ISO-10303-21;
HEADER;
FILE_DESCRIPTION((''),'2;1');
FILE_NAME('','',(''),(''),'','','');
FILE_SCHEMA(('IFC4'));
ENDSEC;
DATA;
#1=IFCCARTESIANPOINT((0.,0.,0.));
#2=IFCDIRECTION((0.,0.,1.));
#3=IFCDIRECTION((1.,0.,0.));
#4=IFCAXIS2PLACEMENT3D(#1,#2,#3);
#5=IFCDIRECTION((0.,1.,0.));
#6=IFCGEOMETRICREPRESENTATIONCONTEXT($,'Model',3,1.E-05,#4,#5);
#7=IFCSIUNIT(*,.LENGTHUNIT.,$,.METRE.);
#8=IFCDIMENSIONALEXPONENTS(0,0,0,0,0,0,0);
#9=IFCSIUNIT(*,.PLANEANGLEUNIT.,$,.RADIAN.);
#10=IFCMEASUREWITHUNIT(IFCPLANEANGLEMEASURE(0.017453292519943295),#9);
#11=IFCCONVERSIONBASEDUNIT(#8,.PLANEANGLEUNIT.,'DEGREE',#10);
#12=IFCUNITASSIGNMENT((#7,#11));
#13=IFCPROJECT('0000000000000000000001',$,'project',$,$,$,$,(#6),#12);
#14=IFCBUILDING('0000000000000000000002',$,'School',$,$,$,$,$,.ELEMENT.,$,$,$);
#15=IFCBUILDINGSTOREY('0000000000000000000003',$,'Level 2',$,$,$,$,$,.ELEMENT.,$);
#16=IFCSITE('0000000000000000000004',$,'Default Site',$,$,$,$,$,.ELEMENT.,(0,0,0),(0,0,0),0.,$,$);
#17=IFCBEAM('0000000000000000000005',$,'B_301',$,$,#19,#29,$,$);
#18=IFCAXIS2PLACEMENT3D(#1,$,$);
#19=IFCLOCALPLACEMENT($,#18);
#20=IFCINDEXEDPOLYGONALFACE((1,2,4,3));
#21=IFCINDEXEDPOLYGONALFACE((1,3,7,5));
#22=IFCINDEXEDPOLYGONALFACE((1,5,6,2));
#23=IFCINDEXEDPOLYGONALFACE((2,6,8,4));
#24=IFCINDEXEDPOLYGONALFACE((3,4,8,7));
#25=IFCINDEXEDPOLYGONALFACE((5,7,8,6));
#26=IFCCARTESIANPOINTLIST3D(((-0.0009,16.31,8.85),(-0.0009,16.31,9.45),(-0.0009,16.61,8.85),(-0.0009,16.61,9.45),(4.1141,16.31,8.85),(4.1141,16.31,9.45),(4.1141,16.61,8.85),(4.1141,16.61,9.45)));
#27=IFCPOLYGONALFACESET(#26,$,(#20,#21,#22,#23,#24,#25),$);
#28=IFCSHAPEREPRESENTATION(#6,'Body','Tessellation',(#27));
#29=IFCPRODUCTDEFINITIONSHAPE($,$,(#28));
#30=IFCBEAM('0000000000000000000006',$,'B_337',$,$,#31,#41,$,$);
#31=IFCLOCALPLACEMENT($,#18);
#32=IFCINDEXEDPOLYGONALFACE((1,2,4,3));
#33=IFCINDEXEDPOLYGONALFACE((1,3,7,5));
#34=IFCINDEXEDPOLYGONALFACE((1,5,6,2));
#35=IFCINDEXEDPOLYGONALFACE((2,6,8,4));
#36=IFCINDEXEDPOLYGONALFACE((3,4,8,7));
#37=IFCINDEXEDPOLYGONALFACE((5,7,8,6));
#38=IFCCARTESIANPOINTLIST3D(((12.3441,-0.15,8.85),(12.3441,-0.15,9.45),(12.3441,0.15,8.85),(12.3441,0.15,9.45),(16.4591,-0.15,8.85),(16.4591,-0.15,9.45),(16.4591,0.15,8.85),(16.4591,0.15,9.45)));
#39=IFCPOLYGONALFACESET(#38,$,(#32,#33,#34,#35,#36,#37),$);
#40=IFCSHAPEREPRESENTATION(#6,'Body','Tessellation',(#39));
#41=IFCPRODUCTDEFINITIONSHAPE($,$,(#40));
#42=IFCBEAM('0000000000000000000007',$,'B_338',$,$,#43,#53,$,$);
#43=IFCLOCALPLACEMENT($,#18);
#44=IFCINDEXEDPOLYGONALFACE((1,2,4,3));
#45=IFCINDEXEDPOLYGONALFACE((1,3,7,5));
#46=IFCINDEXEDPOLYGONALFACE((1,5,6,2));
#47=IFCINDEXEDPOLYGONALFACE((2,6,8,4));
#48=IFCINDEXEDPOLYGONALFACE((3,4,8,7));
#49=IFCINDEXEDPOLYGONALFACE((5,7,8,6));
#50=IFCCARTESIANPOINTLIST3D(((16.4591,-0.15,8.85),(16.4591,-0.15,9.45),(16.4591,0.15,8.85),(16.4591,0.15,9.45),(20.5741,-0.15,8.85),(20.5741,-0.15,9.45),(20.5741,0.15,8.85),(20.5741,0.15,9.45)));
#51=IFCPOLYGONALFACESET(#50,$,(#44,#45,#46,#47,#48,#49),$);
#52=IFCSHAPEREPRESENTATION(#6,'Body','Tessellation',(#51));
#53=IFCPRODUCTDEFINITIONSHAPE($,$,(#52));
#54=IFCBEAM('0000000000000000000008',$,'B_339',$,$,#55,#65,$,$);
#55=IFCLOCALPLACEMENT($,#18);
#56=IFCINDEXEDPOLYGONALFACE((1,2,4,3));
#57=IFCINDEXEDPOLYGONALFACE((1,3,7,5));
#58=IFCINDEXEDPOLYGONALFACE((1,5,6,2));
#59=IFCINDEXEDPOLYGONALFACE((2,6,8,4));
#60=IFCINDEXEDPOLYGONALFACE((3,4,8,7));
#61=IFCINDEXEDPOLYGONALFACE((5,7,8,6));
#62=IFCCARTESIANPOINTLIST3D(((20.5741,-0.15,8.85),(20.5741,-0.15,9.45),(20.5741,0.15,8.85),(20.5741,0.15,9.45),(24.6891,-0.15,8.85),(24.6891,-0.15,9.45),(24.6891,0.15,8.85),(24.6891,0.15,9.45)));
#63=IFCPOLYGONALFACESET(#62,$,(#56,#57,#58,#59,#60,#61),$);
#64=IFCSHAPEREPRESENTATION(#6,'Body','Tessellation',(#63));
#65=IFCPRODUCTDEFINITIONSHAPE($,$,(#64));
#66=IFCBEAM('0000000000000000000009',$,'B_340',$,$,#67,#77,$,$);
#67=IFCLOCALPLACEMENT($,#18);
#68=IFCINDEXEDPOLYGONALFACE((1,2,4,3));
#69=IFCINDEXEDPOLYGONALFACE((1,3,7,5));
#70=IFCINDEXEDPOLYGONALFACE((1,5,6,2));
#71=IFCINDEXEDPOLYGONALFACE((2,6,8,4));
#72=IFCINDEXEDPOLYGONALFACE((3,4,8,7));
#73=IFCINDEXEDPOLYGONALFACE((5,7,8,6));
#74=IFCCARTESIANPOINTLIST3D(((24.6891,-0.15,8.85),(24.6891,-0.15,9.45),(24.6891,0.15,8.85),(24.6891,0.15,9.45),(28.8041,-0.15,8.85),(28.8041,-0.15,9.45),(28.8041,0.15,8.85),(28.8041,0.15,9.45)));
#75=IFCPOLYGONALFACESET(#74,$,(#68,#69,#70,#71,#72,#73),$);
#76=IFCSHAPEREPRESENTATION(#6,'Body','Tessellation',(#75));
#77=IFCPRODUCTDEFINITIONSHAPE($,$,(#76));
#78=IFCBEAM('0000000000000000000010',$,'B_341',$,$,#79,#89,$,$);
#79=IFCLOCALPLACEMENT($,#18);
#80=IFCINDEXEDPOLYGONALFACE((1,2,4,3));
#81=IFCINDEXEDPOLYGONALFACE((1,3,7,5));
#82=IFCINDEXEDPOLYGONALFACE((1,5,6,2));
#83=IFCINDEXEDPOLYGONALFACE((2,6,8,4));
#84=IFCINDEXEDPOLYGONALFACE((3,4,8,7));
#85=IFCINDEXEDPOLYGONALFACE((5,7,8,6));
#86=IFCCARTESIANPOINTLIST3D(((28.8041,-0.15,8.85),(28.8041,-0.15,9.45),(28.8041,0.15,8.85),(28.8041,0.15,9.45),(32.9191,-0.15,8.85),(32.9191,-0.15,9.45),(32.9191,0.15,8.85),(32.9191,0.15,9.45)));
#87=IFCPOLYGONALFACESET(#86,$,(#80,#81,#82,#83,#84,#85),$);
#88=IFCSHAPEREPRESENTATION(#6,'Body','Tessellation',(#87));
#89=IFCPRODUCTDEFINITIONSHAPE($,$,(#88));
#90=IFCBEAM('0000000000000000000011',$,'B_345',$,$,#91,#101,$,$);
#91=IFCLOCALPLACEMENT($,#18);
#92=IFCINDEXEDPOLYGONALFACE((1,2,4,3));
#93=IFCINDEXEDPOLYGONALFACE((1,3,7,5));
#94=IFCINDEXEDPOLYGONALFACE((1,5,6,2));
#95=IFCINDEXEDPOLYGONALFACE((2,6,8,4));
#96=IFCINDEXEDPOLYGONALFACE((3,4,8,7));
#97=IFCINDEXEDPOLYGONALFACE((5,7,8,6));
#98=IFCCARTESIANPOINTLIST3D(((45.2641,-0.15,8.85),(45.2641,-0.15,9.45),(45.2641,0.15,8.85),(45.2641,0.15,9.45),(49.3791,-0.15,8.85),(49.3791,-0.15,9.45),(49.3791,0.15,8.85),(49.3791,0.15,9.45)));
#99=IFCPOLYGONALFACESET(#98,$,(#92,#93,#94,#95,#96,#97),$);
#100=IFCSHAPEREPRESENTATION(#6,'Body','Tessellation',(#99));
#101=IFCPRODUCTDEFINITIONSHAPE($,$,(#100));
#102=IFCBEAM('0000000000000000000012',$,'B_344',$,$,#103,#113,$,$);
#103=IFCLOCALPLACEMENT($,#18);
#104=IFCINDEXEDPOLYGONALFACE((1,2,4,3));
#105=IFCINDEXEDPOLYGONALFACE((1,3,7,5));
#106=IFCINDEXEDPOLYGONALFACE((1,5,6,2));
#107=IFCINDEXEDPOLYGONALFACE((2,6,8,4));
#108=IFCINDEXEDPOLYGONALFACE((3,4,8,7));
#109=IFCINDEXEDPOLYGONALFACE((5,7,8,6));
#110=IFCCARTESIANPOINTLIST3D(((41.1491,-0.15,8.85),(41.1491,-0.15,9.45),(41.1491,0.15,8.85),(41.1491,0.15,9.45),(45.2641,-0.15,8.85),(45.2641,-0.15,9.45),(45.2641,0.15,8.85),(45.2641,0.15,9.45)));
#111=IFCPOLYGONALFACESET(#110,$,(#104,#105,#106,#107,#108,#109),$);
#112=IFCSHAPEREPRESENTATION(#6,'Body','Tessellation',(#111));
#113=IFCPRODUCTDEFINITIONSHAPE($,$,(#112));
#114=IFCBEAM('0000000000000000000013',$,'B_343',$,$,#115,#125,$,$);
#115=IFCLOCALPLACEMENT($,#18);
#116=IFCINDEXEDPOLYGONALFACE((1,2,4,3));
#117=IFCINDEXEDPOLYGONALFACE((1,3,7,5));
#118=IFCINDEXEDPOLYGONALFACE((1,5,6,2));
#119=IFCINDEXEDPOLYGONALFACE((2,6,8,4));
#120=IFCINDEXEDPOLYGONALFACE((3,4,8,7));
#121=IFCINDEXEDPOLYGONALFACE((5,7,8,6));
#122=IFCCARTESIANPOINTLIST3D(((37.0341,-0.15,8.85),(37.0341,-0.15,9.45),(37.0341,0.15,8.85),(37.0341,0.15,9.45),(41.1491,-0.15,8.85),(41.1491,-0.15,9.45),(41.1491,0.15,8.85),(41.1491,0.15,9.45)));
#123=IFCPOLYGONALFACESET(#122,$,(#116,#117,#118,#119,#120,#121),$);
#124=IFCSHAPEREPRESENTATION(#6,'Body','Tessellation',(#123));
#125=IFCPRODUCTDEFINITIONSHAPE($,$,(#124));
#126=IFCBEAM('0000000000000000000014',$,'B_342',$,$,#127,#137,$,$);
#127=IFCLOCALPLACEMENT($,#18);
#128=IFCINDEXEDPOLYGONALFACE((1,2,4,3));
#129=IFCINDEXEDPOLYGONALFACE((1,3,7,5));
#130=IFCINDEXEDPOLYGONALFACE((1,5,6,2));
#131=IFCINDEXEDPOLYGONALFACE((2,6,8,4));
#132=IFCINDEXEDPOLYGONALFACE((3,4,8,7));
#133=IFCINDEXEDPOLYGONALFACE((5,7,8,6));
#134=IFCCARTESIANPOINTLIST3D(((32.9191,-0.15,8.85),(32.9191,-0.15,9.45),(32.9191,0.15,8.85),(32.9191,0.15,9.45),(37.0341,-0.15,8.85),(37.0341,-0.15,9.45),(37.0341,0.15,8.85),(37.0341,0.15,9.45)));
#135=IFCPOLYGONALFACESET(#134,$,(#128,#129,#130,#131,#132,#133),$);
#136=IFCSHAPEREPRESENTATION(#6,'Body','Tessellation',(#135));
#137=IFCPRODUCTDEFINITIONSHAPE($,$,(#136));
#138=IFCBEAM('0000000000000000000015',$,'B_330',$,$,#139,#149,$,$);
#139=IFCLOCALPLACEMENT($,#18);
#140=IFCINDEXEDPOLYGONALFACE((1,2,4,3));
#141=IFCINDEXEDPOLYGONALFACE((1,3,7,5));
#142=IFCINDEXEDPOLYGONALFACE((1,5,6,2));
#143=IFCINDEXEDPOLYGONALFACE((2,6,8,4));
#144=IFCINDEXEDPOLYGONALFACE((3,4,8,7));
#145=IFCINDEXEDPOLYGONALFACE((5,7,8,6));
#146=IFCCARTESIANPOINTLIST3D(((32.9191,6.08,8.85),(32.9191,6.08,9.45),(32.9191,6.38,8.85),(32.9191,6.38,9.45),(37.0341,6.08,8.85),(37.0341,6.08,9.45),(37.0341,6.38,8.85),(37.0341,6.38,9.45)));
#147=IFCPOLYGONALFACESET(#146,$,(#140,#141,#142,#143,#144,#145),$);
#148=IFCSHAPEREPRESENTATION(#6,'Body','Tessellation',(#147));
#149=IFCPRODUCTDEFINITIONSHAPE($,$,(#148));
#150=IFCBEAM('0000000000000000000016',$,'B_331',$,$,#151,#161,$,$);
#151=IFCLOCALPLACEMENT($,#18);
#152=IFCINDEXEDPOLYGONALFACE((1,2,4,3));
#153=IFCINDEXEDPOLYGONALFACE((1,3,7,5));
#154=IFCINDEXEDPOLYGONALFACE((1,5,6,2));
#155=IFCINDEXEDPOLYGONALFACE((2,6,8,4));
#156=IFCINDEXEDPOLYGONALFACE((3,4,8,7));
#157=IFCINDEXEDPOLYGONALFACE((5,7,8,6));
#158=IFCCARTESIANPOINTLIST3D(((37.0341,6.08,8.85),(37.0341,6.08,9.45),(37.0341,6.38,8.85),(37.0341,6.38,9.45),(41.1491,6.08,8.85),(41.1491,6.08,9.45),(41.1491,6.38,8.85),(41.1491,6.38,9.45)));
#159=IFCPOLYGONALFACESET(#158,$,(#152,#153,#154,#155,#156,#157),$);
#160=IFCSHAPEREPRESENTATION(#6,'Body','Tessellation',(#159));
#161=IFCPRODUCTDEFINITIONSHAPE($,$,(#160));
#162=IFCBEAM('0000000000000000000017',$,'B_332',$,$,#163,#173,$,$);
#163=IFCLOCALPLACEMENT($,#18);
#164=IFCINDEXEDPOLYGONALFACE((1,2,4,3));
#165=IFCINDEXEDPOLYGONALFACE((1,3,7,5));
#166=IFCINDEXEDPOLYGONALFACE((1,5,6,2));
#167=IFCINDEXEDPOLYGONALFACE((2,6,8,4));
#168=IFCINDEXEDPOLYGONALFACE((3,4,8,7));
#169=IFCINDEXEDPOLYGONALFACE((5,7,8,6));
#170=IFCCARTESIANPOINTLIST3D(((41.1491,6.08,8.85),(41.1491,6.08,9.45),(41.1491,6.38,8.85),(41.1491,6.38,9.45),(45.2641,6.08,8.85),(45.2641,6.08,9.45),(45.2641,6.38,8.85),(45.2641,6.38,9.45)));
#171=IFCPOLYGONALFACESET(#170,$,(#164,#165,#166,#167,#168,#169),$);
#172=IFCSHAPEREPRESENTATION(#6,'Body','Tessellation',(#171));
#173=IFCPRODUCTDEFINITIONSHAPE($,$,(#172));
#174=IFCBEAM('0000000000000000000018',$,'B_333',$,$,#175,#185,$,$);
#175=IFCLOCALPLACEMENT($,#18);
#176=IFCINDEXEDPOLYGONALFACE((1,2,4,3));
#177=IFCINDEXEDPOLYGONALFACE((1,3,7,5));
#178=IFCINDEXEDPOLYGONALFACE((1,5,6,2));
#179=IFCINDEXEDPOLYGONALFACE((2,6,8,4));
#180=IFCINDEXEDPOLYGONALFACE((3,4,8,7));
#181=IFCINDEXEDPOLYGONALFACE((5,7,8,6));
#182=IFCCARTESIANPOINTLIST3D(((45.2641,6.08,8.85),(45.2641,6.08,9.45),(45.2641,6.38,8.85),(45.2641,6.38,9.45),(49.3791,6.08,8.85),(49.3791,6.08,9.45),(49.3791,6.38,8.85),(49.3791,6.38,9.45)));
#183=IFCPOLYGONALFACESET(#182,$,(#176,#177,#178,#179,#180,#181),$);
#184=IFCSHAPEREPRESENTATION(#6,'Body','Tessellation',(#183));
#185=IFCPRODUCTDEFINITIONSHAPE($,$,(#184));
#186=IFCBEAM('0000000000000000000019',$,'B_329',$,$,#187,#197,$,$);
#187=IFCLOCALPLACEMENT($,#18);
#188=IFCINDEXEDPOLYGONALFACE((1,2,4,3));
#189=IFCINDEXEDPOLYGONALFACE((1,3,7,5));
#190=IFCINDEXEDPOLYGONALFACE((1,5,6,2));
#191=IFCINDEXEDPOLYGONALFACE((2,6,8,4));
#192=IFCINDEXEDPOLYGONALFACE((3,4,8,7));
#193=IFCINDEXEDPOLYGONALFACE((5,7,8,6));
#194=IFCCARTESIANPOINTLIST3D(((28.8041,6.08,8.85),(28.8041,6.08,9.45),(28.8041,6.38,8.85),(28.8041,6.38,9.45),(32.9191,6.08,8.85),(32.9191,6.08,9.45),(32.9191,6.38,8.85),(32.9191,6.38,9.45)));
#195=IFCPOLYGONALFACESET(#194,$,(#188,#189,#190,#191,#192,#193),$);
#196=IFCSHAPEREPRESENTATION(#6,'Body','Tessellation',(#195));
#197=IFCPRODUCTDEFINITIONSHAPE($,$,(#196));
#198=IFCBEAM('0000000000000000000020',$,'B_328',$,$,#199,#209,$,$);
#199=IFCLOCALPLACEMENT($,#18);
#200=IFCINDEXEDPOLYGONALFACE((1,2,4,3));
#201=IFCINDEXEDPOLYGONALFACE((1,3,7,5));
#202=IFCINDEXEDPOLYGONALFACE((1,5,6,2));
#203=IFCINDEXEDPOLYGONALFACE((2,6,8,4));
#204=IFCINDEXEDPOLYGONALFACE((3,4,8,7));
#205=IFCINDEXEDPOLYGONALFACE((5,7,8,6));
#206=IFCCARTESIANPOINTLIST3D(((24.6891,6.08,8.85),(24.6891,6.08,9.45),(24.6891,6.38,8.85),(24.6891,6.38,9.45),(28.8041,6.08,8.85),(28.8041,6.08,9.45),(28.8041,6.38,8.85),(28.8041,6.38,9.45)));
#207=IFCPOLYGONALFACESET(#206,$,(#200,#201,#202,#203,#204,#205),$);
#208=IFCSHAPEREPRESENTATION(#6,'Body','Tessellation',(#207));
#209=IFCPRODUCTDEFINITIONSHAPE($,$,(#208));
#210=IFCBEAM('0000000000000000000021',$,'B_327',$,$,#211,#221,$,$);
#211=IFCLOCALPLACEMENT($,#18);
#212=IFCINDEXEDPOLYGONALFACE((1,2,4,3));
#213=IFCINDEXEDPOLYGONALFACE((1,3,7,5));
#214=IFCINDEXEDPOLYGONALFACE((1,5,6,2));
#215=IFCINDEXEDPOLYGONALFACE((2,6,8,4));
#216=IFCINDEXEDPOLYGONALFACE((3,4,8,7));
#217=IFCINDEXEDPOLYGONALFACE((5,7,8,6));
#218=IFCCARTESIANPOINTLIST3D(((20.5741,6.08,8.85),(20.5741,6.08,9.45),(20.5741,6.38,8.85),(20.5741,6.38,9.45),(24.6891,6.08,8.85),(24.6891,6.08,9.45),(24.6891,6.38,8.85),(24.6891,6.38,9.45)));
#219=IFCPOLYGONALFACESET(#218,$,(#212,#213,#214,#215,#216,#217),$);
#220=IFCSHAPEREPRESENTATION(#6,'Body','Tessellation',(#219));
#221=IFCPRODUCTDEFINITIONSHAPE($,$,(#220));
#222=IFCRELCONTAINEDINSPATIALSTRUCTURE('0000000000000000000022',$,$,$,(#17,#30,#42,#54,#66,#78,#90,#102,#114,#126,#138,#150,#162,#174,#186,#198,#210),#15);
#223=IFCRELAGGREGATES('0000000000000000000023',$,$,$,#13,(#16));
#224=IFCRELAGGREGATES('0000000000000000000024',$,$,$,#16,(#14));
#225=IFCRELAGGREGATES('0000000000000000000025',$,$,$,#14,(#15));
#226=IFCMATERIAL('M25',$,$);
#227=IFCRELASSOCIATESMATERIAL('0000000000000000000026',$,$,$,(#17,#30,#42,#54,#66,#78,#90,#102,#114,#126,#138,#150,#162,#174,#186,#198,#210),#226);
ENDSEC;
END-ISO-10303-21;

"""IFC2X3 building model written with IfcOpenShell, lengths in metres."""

from ifc_helpers import new_model, entity, si_unit, converted_unit, direction, frame, frame_2d, origin_with_axes, place, context, project, spatial, rectangle, extrude, material, element, save


model = new_model("IFC2X3")

# Units and contexts
model_context = context("Model", 3, precision=1e-05, world=origin_with_axes(), true_north=direction((0.0, 1.0, 0.0)))
ifc_project = project(units=[si_unit("LENGTHUNIT", "METRE"), converted_unit("PLANEANGLEUNIT", "DEGREE", entity("IfcPlaneAngleMeasure", 0.017453292519943295), si_unit("PLANEANGLEUNIT", "RADIAN"), dimensions=[0, 0, 0, 0, 0, 0, 0])], contexts=[model_context])

# Site, building, storey
site = spatial("IfcSite", under=ifc_project, Name="Default Site", CompositionType="ELEMENT", RefLatitude=(0, 0, 0), RefLongitude=(0, 0, 0), RefElevation=0.0)
building = spatial("IfcBuilding", under=site, Name="School", CompositionType="ELEMENT")
storey = spatial("IfcBuildingStorey", under=building, Name="Level 2", CompositionType="ELEMENT")

# Beams
ifc_material = material(Name="M25")
placement = place(None, origin_with_axes())
element("IfcBeam", 1, at=placement, inside=storey, material=ifc_material, Name="B_301", context=model_context, shape_type="SweptSolid", body=[
    extrude(rectangle(XDim=0.3, YDim=0.6, at=frame_2d((0.0, 0.0), x_axis=(0.0, 1.0, 0.0))), frame((-0.0009, 16.46, 9.15), z_axis=(1.0, 0.0, 0.0), x_axis=(0.0, 0.0, -1.0)), (0.0, 0.0, 1.0), 4.115),
])
element("IfcBeam", 2, at=placement, inside=storey, material=ifc_material, Name="B_337", context=model_context, shape_type="SweptSolid", body=[
    extrude(rectangle(XDim=0.3, YDim=0.6, at=frame_2d((0.0, 0.0), x_axis=(0.0, 1.0, 0.0))), frame((12.3441, 0.0, 9.15), z_axis=(1.0, 0.0, 0.0), x_axis=(0.0, 0.0, -1.0)), (0.0, 0.0, 1.0), 4.115),
])
element("IfcBeam", 3, at=placement, inside=storey, material=ifc_material, Name="B_338", context=model_context, shape_type="SweptSolid", body=[
    extrude(rectangle(XDim=0.3, YDim=0.6, at=frame_2d((0.0, 0.0), x_axis=(0.0, 1.0, 0.0))), frame((16.4591, 0.0, 9.15), z_axis=(1.0, 0.0, 0.0), x_axis=(0.0, 0.0, -1.0)), (0.0, 0.0, 1.0), 4.115),
])
element("IfcBeam", 4, at=placement, inside=storey, material=ifc_material, Name="B_339", context=model_context, shape_type="SweptSolid", body=[
    extrude(rectangle(XDim=0.3, YDim=0.6, at=frame_2d((0.0, 0.0), x_axis=(0.0, 1.0, 0.0))), frame((20.5741, 0.0, 9.15), z_axis=(1.0, 0.0, 0.0), x_axis=(0.0, 0.0, -1.0)), (0.0, 0.0, 1.0), 4.115),
])
element("IfcBeam", 5, at=placement, inside=storey, material=ifc_material, Name="B_340", context=model_context, shape_type="SweptSolid", body=[
    extrude(rectangle(XDim=0.3, YDim=0.6, at=frame_2d((0.0, 0.0), x_axis=(0.0, 1.0, 0.0))), frame((24.6891, 0.0, 9.15), z_axis=(1.0, 0.0, 0.0), x_axis=(0.0, 0.0, -1.0)), (0.0, 0.0, 1.0), 4.115),
])
element("IfcBeam", 6, at=placement, inside=storey, material=ifc_material, Name="B_341", context=model_context, shape_type="SweptSolid", body=[
    extrude(rectangle(XDim=0.3, YDim=0.6, at=frame_2d((0.0, 0.0), x_axis=(0.0, 1.0, 0.0))), frame((28.8041, 0.0, 9.15), z_axis=(1.0, 0.0, 0.0), x_axis=(0.0, 0.0, -1.0)), (0.0, 0.0, 1.0), 4.115),
])
element("IfcBeam", 7, at=placement, inside=storey, material=ifc_material, Name="B_345", context=model_context, shape_type="SweptSolid", body=[
    extrude(rectangle(XDim=0.3, YDim=0.6, at=frame_2d((0.0, 0.0), x_axis=(0.0, 1.0, 0.0))), frame((45.2641, 0.0, 9.15), z_axis=(1.0, 0.0, 0.0), x_axis=(0.0, 0.0, -1.0)), (0.0, 0.0, 1.0), 4.115),
])
element("IfcBeam", 8, at=placement, inside=storey, material=ifc_material, Name="B_344", context=model_context, shape_type="SweptSolid", body=[
    extrude(rectangle(XDim=0.3, YDim=0.6, at=frame_2d((0.0, 0.0), x_axis=(0.0, 1.0, 0.0))), frame((41.1491, 0.0, 9.15), z_axis=(1.0, 0.0, 0.0), x_axis=(0.0, 0.0, -1.0)), (0.0, 0.0, 1.0), 4.115),
])
element("IfcBeam", 9, at=placement, inside=storey, material=ifc_material, Name="B_343", context=model_context, shape_type="SweptSolid", body=[
    extrude(rectangle(XDim=0.3, YDim=0.6, at=frame_2d((0.0, 0.0), x_axis=(0.0, 1.0, 0.0))), frame((37.0341, 0.0, 9.15), z_axis=(1.0, 0.0, 0.0), x_axis=(0.0, 0.0, -1.0)), (0.0, 0.0, 1.0), 4.115),
])
element("IfcBeam", 10, at=placement, inside=storey, material=ifc_material, Name="B_342", context=model_context, shape_type="SweptSolid", body=[
    extrude(rectangle(XDim=0.3, YDim=0.6, at=frame_2d((0.0, 0.0), x_axis=(0.0, 1.0, 0.0))), frame((32.9191, 0.0, 9.15), z_axis=(1.0, 0.0, 0.0), x_axis=(0.0, 0.0, -1.0)), (0.0, 0.0, 1.0), 4.115),
])
element("IfcBeam", 11, at=placement, inside=storey, material=ifc_material, Name="B_330", context=model_context, shape_type="SweptSolid", body=[
    extrude(rectangle(XDim=0.3, YDim=0.6, at=frame_2d((0.0, 0.0), x_axis=(0.0, 1.0, 0.0))), frame((32.9191, 6.23, 9.15), z_axis=(1.0, 0.0, 0.0), x_axis=(0.0, 0.0, -1.0)), (0.0, 0.0, 1.0), 4.115),
])
element("IfcBeam", 12, at=placement, inside=storey, material=ifc_material, Name="B_331", context=model_context, shape_type="SweptSolid", body=[
    extrude(rectangle(XDim=0.3, YDim=0.6, at=frame_2d((0.0, 0.0), x_axis=(0.0, 1.0, 0.0))), frame((37.0341, 6.23, 9.15), z_axis=(1.0, 0.0, 0.0), x_axis=(0.0, 0.0, -1.0)), (0.0, 0.0, 1.0), 4.115),
])
element("IfcBeam", 13, at=placement, inside=storey, material=ifc_material, Name="B_332", context=model_context, shape_type="SweptSolid", body=[
    extrude(rectangle(XDim=0.3, YDim=0.6, at=frame_2d((0.0, 0.0), x_axis=(0.0, 1.0, 0.0))), frame((41.1491, 6.23, 9.15), z_axis=(1.0, 0.0, 0.0), x_axis=(0.0, 0.0, -1.0)), (0.0, 0.0, 1.0), 4.115),
])
element("IfcBeam", 14, at=placement, inside=storey, material=ifc_material, Name="B_333", context=model_context, shape_type="SweptSolid", body=[
    extrude(rectangle(XDim=0.3, YDim=0.6, at=frame_2d((0.0, 0.0), x_axis=(0.0, 1.0, 0.0))), frame((45.2641, 6.23, 9.15), z_axis=(1.0, 0.0, 0.0), x_axis=(0.0, 0.0, -1.0)), (0.0, 0.0, 1.0), 4.115),
])
element("IfcBeam", 15, at=placement, inside=storey, material=ifc_material, Name="B_329", context=model_context, shape_type="SweptSolid", body=[
    extrude(rectangle(XDim=0.3, YDim=0.6, at=frame_2d((0.0, 0.0), x_axis=(0.0, 1.0, 0.0))), frame((28.8041, 6.23, 9.15), z_axis=(1.0, 0.0, 0.0), x_axis=(0.0, 0.0, -1.0)), (0.0, 0.0, 1.0), 4.115),
])
element("IfcBeam", 16, at=placement, inside=storey, material=ifc_material, Name="B_328", context=model_context, shape_type="SweptSolid", body=[
    extrude(rectangle(XDim=0.3, YDim=0.6, at=frame_2d((0.0, 0.0), x_axis=(0.0, 1.0, 0.0))), frame((24.6891, 6.23, 9.15), z_axis=(1.0, 0.0, 0.0), x_axis=(0.0, 0.0, -1.0)), (0.0, 0.0, 1.0), 4.115),
])
element("IfcBeam", 17, at=placement, inside=storey, material=ifc_material, Name="B_327", context=model_context, shape_type="SweptSolid", body=[
    extrude(rectangle(XDim=0.3, YDim=0.6, at=frame_2d((0.0, 0.0), x_axis=(0.0, 1.0, 0.0))), frame((20.5741, 6.23, 9.15), z_axis=(1.0, 0.0, 0.0), x_axis=(0.0, 0.0, -1.0)), (0.0, 0.0, 1.0), 4.115),
])

save(model, "model.ifc")
